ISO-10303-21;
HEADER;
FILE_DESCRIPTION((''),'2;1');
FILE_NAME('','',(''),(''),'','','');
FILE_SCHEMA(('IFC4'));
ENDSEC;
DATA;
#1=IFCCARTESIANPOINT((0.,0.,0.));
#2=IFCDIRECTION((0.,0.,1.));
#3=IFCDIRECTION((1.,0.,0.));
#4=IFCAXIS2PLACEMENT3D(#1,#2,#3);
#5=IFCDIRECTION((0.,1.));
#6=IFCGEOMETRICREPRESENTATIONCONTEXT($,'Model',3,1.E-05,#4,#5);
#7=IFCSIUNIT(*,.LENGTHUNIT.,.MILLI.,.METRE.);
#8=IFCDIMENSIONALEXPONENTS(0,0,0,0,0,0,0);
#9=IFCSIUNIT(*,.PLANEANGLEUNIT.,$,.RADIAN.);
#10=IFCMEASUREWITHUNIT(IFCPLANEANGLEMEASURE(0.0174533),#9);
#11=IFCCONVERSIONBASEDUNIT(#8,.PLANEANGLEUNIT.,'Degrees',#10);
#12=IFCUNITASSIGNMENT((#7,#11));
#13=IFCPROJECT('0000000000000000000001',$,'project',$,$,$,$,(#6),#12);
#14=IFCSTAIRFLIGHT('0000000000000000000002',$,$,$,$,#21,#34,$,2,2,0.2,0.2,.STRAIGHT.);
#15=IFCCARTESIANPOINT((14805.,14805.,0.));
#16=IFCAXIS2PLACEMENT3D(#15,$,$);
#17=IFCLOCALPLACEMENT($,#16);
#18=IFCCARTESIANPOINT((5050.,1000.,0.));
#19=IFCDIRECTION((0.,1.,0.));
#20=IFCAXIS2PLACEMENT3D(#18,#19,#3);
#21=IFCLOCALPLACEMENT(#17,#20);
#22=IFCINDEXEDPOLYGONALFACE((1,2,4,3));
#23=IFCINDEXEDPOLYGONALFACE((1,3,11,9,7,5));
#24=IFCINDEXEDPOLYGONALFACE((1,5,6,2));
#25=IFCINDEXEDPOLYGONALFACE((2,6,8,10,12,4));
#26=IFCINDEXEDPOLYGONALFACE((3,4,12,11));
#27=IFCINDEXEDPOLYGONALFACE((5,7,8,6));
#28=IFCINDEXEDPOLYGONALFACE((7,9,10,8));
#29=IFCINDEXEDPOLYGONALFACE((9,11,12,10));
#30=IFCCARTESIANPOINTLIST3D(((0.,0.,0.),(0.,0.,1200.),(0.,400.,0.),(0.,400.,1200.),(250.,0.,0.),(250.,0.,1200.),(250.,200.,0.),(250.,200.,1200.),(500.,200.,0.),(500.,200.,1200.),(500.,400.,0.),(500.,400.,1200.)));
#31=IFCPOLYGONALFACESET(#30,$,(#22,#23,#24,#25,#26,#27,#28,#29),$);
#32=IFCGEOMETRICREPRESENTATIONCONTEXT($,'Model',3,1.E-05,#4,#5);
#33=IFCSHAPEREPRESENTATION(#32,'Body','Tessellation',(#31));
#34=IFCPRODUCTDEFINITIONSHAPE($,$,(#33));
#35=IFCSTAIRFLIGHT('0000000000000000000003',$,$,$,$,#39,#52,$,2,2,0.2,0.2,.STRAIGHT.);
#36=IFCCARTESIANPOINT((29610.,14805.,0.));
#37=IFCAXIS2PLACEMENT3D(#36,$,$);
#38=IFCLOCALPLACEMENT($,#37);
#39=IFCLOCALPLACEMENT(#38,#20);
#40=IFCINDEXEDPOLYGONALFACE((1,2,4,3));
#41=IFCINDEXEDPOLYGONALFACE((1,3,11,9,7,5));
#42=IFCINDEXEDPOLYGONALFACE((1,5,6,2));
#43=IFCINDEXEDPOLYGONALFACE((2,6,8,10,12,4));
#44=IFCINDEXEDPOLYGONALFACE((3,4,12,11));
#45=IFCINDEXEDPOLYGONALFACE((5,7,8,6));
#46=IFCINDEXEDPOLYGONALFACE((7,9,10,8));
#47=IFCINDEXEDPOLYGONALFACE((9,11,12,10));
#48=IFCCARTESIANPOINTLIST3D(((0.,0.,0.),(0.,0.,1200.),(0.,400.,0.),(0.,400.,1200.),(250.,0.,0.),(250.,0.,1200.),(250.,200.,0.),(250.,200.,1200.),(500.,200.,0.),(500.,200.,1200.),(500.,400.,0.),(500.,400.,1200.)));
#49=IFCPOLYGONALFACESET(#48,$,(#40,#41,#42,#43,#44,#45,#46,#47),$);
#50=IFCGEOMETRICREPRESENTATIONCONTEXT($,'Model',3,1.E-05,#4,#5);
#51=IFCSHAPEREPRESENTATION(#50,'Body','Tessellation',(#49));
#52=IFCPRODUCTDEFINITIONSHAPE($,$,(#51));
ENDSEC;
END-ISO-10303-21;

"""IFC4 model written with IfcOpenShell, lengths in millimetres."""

from ifc_helpers import new_model, entity, si_unit, converted_unit, direction, frame, origin_with_axes, place, context, project, polyline, outline, extrude, element, save


model = new_model("IFC4")

# Units and contexts
model_context_1 = context("Model", 3, precision=1e-05, world=origin_with_axes(), true_north=direction((0.0, 1.0)))
model_context_2 = context("Model", 3, precision=1e-05, world=origin_with_axes(), true_north=direction((0.0, 1.0)))
model_context_3 = context("Model", 3, precision=1e-05, world=origin_with_axes(), true_north=direction((0.0, 1.0)))
ifc_project = project(units=[si_unit("LENGTHUNIT", "METRE", prefix="MILLI"), converted_unit("PLANEANGLEUNIT", "Degrees", entity("IfcPlaneAngleMeasure", 0.0174533), si_unit("PLANEANGLEUNIT", "RADIAN"), dimensions=[0, 0, 0, 0, 0, 0, 0])], contexts=[model_context_1])

# Shared definitions
placement_1 = place(None, frame((29610.0, 14805.0, 0.0)))

# Shared definitions
placement_2 = place(None, frame((14805.0, 14805.0, 0.0)))

# Stair flights
stair_flight_1_placement = place(placement_2, frame((5050.0, 1000.0, 0.0), z_axis=(0.0, 1.0, 0.0), x_axis=(1.0, 0.0, 0.0)))
element("IfcStairFlight", 1, at=stair_flight_1_placement, NumberOfRisers=2, NumberOfTreads=2, PredefinedType="STRAIGHT", RiserHeight=0.2, TreadLength=0.2, context=model_context_2, shape_type="SweptSolid", body=[
    extrude(outline(polyline([(0.0, 0.0), (250.0, 0.0), (250.0, 200.0), (500.0, 200.0), (500.0, 400.0), (0.0, 400.0), (0.0, 0.0)])), origin_with_axes(), (0.0, 0.0, 1.0), 1200.0),
])
stair_flight_2_placement = place(placement_1, frame((5050.0, 1000.0, 0.0), z_axis=(0.0, 1.0, 0.0), x_axis=(1.0, 0.0, 0.0)))
element("IfcStairFlight", 2, at=stair_flight_2_placement, NumberOfRisers=2, NumberOfTreads=2, PredefinedType="STRAIGHT", RiserHeight=0.2, TreadLength=0.2, context=model_context_3, shape_type="SweptSolid", body=[
    extrude(outline(polyline([(0.0, 0.0), (250.0, 0.0), (250.0, 200.0), (500.0, 200.0), (500.0, 400.0), (0.0, 400.0), (0.0, 0.0)])), origin_with_axes(), (0.0, 0.0, 1.0), 1200.0),
])

save(model, "model.ifc")
